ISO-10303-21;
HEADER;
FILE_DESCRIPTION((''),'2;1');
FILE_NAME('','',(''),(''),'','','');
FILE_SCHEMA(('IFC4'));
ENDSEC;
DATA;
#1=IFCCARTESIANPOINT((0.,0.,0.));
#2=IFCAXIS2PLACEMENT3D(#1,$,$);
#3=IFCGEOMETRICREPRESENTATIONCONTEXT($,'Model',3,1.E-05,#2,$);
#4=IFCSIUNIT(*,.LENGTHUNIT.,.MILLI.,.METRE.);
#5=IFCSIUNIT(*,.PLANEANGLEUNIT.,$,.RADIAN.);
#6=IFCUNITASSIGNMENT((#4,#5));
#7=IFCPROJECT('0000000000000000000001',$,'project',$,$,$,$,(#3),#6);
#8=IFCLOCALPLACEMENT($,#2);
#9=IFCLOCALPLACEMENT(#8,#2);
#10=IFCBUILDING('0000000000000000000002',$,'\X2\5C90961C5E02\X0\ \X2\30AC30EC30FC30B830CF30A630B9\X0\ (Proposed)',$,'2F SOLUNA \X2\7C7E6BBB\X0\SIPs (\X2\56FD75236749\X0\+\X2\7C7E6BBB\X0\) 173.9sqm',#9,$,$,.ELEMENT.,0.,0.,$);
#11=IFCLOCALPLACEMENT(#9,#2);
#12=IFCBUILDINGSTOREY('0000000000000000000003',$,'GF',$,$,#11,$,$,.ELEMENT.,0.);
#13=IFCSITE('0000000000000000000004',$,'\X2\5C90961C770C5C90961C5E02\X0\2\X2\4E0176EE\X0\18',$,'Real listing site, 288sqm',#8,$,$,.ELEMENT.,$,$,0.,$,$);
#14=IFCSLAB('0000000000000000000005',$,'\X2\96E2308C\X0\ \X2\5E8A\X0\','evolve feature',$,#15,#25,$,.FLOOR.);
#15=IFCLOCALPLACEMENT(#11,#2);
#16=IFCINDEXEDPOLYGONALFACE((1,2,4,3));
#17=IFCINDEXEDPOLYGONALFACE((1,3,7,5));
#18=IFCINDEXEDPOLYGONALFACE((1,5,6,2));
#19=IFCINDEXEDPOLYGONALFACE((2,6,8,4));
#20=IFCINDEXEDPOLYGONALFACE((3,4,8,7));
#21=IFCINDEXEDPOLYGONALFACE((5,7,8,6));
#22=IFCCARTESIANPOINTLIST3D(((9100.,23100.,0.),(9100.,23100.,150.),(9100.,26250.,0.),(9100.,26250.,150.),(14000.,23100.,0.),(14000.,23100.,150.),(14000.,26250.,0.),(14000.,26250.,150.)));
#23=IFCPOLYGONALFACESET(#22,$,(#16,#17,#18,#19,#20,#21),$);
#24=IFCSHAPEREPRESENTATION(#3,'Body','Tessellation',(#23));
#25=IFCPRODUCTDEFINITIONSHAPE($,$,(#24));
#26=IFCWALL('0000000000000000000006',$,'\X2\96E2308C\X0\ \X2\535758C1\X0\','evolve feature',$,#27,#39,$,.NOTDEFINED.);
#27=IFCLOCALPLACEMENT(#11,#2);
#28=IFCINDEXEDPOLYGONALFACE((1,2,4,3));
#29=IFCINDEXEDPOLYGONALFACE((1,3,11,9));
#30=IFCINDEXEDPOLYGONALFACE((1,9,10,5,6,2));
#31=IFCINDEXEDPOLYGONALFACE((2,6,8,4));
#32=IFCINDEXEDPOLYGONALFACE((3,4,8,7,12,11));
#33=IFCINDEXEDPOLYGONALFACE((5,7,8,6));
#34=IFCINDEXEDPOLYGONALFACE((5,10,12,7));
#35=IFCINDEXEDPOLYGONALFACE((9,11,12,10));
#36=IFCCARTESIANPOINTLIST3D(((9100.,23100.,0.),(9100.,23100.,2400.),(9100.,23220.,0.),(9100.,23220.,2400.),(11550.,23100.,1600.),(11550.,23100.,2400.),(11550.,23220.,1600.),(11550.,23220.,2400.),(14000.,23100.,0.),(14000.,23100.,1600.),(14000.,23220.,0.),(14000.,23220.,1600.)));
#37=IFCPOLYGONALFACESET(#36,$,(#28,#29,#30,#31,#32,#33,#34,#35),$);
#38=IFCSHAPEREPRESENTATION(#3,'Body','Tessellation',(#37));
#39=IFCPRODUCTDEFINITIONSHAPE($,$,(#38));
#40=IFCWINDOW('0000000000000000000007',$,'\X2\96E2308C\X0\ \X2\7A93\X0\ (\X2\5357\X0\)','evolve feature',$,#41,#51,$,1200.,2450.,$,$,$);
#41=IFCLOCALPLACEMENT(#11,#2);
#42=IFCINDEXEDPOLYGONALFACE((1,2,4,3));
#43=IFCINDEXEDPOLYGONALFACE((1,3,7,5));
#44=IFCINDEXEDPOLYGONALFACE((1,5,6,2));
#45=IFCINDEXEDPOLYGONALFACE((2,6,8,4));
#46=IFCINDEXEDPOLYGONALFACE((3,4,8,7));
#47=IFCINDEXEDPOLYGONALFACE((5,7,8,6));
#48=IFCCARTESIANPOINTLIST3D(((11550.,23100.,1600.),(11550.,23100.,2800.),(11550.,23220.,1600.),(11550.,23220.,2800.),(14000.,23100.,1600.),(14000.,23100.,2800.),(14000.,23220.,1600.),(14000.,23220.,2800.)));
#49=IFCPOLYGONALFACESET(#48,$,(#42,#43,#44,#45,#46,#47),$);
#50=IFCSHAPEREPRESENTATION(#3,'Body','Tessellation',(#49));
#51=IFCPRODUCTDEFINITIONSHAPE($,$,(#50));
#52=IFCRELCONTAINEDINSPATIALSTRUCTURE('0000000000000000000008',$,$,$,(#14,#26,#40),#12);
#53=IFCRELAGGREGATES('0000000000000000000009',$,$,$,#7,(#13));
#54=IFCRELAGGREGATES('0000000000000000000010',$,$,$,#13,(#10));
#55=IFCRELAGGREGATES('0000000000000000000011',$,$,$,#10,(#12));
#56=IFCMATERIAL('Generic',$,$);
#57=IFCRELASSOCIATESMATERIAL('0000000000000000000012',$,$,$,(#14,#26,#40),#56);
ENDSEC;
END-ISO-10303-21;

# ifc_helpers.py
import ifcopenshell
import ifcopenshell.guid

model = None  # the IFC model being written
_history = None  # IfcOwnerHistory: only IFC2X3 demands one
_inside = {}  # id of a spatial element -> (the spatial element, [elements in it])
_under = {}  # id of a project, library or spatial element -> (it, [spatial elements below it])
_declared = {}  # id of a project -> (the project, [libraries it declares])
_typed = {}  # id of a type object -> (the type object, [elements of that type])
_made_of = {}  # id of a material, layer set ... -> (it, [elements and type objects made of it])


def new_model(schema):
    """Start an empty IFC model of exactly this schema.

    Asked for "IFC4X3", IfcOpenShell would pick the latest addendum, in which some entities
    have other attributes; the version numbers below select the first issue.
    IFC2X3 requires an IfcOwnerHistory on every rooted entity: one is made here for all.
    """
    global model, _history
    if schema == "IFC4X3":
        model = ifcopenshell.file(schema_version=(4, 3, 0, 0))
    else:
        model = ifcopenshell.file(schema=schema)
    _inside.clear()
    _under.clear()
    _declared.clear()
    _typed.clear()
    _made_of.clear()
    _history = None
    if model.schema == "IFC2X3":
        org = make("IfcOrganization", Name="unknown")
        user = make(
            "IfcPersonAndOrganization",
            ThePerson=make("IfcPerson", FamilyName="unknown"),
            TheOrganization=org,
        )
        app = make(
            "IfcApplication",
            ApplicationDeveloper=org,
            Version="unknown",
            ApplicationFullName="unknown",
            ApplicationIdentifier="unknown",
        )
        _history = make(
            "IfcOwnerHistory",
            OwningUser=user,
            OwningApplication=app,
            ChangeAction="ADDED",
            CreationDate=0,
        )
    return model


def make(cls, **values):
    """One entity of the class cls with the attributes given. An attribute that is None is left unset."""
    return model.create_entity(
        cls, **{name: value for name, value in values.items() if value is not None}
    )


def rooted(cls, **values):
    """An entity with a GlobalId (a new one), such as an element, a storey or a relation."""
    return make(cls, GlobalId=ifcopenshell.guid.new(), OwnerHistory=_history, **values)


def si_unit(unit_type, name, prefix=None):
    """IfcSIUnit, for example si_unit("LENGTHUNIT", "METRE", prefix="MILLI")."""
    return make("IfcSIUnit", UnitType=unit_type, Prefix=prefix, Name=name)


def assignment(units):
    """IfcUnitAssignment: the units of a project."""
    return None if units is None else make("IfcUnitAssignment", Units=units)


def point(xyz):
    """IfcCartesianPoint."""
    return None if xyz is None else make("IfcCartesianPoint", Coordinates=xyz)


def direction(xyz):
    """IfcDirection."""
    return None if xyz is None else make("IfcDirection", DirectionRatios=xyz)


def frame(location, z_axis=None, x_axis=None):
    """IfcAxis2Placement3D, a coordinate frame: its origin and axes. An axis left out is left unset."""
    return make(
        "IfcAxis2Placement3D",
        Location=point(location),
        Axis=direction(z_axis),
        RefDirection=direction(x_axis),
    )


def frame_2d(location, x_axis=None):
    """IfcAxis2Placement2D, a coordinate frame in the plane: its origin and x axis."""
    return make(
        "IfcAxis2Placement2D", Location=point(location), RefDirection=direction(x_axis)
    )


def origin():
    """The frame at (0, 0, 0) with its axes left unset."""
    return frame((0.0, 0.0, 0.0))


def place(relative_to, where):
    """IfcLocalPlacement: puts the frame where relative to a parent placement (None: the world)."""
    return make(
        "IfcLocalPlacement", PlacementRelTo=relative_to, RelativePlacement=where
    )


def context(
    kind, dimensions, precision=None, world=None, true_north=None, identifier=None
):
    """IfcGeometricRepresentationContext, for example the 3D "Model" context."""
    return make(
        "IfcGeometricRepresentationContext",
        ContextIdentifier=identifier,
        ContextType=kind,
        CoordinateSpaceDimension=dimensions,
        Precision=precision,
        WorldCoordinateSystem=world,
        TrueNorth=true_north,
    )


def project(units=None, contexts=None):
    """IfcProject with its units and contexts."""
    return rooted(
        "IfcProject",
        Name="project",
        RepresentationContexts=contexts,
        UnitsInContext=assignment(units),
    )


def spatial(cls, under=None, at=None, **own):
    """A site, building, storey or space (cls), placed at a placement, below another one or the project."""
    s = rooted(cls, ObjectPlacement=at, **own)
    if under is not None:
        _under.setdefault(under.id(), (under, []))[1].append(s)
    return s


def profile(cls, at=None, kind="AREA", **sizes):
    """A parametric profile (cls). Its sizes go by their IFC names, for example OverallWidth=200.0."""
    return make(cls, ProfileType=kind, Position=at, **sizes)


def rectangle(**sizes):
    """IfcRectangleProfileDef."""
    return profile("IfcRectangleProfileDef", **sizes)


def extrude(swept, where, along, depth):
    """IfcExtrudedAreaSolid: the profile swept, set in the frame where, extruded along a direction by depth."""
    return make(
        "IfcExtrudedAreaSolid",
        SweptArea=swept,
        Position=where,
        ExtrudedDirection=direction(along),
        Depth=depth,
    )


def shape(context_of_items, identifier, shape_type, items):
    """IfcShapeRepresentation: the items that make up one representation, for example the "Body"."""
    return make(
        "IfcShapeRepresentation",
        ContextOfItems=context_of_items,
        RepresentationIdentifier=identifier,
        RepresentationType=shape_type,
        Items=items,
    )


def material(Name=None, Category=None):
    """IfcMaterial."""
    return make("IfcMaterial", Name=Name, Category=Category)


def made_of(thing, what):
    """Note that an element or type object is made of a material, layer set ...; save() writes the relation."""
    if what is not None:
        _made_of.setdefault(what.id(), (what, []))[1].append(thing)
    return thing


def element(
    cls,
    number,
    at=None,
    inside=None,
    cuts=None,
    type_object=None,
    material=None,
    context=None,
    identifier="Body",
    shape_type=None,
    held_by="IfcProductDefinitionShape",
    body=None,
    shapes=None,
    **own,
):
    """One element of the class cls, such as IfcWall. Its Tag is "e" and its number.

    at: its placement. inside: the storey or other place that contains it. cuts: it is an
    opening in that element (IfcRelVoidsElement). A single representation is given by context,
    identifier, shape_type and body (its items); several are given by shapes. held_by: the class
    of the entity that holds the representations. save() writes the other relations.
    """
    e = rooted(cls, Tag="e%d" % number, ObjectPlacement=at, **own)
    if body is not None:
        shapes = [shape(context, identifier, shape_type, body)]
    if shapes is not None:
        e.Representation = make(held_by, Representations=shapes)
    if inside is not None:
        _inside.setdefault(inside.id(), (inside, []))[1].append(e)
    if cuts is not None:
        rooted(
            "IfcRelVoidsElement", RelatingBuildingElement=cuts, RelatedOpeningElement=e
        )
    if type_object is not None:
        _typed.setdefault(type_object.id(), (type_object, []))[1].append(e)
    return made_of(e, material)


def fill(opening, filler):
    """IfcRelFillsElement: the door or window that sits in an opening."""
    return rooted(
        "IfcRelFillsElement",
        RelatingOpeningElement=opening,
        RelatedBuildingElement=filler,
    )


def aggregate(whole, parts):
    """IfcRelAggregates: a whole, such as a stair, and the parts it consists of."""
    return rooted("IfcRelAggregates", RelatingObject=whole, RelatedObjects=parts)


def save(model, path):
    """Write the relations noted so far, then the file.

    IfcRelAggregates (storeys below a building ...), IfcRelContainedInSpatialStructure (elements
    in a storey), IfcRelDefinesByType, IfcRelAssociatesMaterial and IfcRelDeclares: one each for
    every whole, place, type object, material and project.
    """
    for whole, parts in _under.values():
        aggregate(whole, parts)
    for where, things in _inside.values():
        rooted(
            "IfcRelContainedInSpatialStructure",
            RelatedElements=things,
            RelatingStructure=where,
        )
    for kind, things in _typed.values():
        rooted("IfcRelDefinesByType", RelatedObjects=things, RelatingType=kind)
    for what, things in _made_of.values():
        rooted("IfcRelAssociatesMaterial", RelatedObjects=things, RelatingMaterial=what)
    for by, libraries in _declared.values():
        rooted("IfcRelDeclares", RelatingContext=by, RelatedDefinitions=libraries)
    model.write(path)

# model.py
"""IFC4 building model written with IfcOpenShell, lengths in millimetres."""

from ifc_helpers import new_model, si_unit, frame, frame_2d, origin, place, context, project, spatial, rectangle, extrude, material, element, fill, save


model = new_model("IFC4")

# Units and contexts
model_context = context("Model", 3, precision=1e-05, world=origin())
ifc_project = project(units=[si_unit("LENGTHUNIT", "METRE", prefix="MILLI"), si_unit("PLANEANGLEUNIT", "RADIAN")], contexts=[model_context])

# Site, building, storey
site_placement = place(None, origin())
site = spatial("IfcSite", under=ifc_project, at=site_placement, Name="岐阜県岐阜市2丁目18", ObjectType="Real listing site, 288sqm", CompositionType="ELEMENT", RefElevation=0.0)
building_placement = place(site_placement, origin())
building = spatial("IfcBuilding", under=site, at=building_placement, Name="岐阜市 ガレージハウス (Proposed)", ObjectType="2F SOLUNA 籾殻SIPs (国産杉+籾殻) 173.9sqm", CompositionType="ELEMENT", ElevationOfRefHeight=0.0, ElevationOfTerrain=0.0)
storey_placement = place(building_placement, origin())
storey = spatial("IfcBuildingStorey", under=building, at=storey_placement, Name="GF", CompositionType="ELEMENT", Elevation=0.0)

# Slab
ifc_material_1 = material(Name="Generic")
slab_placement = place(storey_placement, frame((4550.0, 11550.0, 0.0)))
element("IfcSlab", 1, at=slab_placement, inside=storey, material=ifc_material_1, Name="離れ 床", Description="evolve feature", PredefinedType="FLOOR", context=model_context, shape_type="SweptSolid", body=[
    extrude(rectangle(XDim=4900.0, YDim=3150.0, at=frame_2d((2450.0, 1575.0))), frame((4550.0, 11550.0, 0.0)), (0.0, 0.0, 1.0), 150.0),
])

# Wall, opening, window
wall_1_placement = place(storey_placement, frame((4550.0, 11550.0, 0.0)))
wall_1 = element("IfcWall", 2, at=wall_1_placement, inside=storey, material=ifc_material_1, Name="離れ 南壁", Description="evolve feature", PredefinedType="NOTDEFINED", context=model_context, shape_type="SweptSolid", body=[
    extrude(rectangle(XDim=4900.0, YDim=120.0, at=frame_2d((2450.0, 60.0))), frame((4550.0, 11550.0, 0.0)), (0.0, 0.0, 1.0), 2400.0),
])
opening_1_placement = place(storey_placement, frame((5775.0, 11550.0, 800.0)))
opening_1 = element("IfcOpeningElement", 3, at=opening_1_placement, cuts=wall_1, PredefinedType="NOTDEFINED", context=model_context, shape_type="SweptSolid", body=[
    extrude(rectangle(XDim=2450.0, YDim=120.0, at=frame_2d((1225.0, 60.0))), frame((5775.0, 11550.0, 800.0)), (0.0, 0.0, 1.0), 1200.0),
])
window_1_placement = place(storey_placement, frame((5775.0, 11550.0, 800.0)))
window_1 = element("IfcWindow", 4, at=window_1_placement, inside=storey, material=ifc_material_1, Name="離れ 窓 (南)", Description="evolve feature", OverallHeight=1200.0, OverallWidth=2450.0, context=model_context, shape_type="SweptSolid", body=[
    extrude(rectangle(XDim=2450.0, YDim=120.0, at=frame_2d((1225.0, 60.0))), frame((5775.0, 11550.0, 800.0)), (0.0, 0.0, 1.0), 1200.0),
])
fill(opening_1, window_1)

save(model, "model.ifc")
